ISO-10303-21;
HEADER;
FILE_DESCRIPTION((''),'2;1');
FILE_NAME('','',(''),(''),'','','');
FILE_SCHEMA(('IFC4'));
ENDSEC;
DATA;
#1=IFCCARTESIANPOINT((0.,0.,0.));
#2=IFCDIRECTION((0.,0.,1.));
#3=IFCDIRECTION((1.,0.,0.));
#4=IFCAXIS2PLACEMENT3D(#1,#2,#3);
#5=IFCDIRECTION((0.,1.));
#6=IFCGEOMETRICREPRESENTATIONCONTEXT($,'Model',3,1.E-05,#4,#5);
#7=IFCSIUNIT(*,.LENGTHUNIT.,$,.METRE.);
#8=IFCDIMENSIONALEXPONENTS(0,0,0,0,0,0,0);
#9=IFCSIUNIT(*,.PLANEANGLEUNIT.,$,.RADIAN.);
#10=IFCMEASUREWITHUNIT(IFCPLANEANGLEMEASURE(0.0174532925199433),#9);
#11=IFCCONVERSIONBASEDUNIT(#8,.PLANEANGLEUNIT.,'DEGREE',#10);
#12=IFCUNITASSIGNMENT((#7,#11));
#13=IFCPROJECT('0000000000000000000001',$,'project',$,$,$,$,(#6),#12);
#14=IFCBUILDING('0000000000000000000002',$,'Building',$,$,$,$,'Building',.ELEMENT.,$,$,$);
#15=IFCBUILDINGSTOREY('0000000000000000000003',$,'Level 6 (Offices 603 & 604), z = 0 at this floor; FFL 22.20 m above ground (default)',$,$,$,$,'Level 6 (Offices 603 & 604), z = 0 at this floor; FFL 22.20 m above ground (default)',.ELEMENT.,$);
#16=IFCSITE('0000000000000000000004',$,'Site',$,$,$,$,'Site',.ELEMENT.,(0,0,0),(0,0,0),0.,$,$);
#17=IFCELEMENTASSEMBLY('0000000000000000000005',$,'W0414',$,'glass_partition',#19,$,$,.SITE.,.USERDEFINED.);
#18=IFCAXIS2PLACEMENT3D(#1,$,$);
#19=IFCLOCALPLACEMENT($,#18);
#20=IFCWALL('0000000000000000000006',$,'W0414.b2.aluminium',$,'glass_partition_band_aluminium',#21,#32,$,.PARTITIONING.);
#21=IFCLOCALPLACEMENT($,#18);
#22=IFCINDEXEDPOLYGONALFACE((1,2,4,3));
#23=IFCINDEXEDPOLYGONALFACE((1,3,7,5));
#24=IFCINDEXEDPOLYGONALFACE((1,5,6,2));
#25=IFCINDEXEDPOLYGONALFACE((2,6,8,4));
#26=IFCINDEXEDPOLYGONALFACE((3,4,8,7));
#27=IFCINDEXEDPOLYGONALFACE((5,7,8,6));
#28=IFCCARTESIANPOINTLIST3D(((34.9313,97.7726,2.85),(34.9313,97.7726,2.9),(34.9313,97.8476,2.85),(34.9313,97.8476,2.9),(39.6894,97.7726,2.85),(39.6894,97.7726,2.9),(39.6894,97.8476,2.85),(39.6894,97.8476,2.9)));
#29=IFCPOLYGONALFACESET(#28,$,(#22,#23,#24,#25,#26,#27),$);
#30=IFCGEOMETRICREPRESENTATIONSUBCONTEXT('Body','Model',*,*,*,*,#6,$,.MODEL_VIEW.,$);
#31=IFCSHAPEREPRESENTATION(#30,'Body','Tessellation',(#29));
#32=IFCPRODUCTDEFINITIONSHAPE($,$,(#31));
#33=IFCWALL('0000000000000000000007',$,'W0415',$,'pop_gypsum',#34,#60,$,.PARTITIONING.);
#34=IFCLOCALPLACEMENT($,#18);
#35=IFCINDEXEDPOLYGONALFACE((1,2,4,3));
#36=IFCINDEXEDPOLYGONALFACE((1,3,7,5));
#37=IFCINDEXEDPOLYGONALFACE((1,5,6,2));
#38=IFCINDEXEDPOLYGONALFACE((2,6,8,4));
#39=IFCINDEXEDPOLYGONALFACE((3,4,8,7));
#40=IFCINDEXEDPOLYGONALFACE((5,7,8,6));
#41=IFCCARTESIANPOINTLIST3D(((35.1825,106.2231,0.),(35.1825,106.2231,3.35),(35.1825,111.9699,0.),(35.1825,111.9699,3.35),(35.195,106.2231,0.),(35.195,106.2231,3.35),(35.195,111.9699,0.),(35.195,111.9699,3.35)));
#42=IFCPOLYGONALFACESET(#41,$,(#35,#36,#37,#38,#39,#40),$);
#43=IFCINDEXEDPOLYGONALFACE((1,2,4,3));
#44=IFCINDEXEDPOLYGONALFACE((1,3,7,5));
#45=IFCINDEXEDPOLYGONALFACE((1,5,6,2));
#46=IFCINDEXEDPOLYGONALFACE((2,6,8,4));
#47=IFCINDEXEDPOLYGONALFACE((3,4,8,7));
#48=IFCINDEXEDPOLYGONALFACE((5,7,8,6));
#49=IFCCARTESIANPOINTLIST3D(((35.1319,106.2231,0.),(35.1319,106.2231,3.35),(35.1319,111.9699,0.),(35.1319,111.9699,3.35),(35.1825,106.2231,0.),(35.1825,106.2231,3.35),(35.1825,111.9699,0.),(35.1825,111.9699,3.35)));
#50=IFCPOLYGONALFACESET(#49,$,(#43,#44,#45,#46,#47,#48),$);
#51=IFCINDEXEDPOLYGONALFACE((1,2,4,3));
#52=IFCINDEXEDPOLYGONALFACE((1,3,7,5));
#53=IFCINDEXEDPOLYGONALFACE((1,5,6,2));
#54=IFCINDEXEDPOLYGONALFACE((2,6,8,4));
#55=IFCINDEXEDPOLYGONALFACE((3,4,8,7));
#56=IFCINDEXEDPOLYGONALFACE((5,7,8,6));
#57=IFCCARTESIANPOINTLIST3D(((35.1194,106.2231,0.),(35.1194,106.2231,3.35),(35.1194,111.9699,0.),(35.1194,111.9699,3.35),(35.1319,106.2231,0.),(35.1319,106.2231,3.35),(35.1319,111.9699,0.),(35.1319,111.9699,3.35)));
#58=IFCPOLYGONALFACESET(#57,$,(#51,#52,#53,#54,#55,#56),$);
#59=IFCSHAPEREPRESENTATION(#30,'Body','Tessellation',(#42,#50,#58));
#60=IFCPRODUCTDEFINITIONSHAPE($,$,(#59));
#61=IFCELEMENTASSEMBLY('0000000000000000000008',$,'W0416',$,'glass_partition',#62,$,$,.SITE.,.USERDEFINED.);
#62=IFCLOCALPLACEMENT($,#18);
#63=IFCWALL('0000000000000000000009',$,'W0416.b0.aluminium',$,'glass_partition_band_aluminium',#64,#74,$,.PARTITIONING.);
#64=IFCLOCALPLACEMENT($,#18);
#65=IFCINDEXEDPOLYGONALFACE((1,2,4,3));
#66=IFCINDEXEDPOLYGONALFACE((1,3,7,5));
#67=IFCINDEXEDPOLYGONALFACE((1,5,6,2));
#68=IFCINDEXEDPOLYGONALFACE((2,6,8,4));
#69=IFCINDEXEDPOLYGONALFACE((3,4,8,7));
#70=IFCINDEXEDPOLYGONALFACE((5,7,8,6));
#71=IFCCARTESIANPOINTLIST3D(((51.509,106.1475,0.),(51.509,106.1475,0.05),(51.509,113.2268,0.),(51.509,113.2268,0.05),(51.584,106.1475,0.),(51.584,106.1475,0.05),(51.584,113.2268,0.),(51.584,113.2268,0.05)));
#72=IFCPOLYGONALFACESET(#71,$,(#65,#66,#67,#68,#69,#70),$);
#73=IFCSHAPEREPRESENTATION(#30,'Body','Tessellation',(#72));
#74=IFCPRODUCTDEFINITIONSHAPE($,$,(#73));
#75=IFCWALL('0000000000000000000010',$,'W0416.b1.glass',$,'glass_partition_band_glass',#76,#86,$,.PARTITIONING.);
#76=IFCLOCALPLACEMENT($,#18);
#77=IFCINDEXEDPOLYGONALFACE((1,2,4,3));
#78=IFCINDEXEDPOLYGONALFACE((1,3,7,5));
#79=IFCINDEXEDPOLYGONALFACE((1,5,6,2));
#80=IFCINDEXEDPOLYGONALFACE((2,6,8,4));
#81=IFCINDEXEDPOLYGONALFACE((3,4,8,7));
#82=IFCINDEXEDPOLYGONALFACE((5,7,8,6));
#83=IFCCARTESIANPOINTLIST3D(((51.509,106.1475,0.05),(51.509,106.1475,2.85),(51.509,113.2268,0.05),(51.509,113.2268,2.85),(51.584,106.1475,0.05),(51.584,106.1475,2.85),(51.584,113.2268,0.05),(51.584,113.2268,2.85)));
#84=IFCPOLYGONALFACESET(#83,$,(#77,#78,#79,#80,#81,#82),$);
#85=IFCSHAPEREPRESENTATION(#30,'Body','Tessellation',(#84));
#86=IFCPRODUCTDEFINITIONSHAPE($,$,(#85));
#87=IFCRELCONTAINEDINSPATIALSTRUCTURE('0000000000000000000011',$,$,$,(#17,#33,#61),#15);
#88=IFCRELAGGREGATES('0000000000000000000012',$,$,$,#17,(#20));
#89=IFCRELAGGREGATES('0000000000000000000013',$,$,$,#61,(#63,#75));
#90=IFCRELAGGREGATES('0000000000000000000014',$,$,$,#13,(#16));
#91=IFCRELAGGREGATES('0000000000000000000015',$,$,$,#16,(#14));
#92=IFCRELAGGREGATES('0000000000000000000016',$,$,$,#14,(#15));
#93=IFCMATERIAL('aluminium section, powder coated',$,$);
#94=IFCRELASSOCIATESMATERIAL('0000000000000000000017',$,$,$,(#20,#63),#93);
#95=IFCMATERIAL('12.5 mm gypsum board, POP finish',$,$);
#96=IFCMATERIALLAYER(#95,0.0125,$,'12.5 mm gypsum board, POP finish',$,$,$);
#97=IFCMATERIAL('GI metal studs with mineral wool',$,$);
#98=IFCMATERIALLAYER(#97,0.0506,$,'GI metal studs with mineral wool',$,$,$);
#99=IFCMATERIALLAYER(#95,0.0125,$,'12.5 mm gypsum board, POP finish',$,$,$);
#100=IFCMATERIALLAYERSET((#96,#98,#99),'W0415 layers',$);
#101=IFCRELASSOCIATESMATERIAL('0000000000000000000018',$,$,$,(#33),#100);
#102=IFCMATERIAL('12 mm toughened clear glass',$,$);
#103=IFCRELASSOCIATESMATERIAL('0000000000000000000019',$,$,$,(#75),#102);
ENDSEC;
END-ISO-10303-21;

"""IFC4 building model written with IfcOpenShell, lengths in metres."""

from ifc_helpers import new_model, entity, si_unit, converted_unit, direction, frame, frame_2d, origin_with_axes, place, context, subcontext, project, spatial, rectangle, extrude, material, layer, layer_set, layer_usage, element, aggregate, save


model = new_model("IFC4")

# Units and contexts
model_context = context("Model", 3, precision=1e-05, world=origin_with_axes(), true_north=direction((0.0, 1.0)))
body_context = subcontext(model_context, "Body", "Model", "MODEL_VIEW")
ifc_project = project(units=[si_unit("LENGTHUNIT", "METRE"), converted_unit("PLANEANGLEUNIT", "DEGREE", entity("IfcPlaneAngleMeasure", 0.0174532925199433), si_unit("PLANEANGLEUNIT", "RADIAN"), dimensions=[0, 0, 0, 0, 0, 0, 0])], contexts=[model_context])

# Site, building, storey
site = spatial("IfcSite", under=ifc_project, Name="Site", LongName="Site", CompositionType="ELEMENT", RefLatitude=(0, 0, 0), RefLongitude=(0, 0, 0), RefElevation=0.0)
building = spatial("IfcBuilding", under=site, Name="Building", LongName="Building", CompositionType="ELEMENT")
storey = spatial("IfcBuildingStorey", under=building, Name="Level 6 (Offices 603 & 604), z = 0 at this floor; FFL 22.20 m above ground (default)", LongName="Level 6 (Offices 603 & 604), z = 0 at this floor; FFL 22.20 m above ground (default)", CompositionType="ELEMENT")

# Shared definitions
ifc_material_1 = material(Name="aluminium section, powder coated")
placement = place(None, origin_with_axes())

# Shared definitions
ifc_material_2 = material(Name="12.5 mm gypsum board, POP finish")
ifc_material_3 = material(Name="GI metal studs with mineral wool")

# Shared definitions
ifc_material_4 = material(Name="12 mm toughened clear glass")

# Element assembly, wall
assembly_1 = element("IfcElementAssembly", 1, inside=storey, Name="W0414", ObjectType="glass_partition", AssemblyPlace="SITE", PredefinedType="USERDEFINED")
wall_1 = element("IfcWall", 2, at=placement, material=ifc_material_1, Name="W0414.b2.aluminium", ObjectType="glass_partition_band_aluminium", PredefinedType="PARTITIONING", context=body_context, shape_type="SweptSolid", body=[
    extrude(rectangle(XDim=4.7581, YDim=0.075, at=frame_2d((0.0, 0.0), x_axis=(1.0, 0.0))), frame((37.3103, 97.8101, 2.85), z_axis=(0.0, 0.0, 1.0), x_axis=(1.0, 0.0, 0.0)), (0.0, 0.0, 1.0), 0.05),
])
aggregate(assembly_1, [wall_1])

# Wall
ifc_layer_1 = layer(ifc_material_2, 0.0125, Name="12.5 mm gypsum board, POP finish")
ifc_layer_2 = layer(ifc_material_3, 0.0506, Name="GI metal studs with mineral wool")
ifc_layer_3 = layer(ifc_material_2, 0.0125, Name="12.5 mm gypsum board, POP finish")
ifc_layer_set_1 = layer_set([ifc_layer_1, ifc_layer_2, ifc_layer_3], Name="W0415 layers")
ifc_layer_usage_1 = layer_usage(ifc_layer_set_1, "AXIS2", "POSITIVE", -0.0378)
element("IfcWall", 3, at=placement, inside=storey, material=ifc_layer_usage_1, Name="W0415", ObjectType="pop_gypsum", PredefinedType="PARTITIONING", context=body_context, shape_type="SweptSolid", body=[
    extrude(rectangle(XDim=5.7468, YDim=0.0125, at=frame_2d((0.0, 0.0), x_axis=(0.0, 1.0))), frame((35.1887, 109.0965, 0.0), z_axis=(0.0, 0.0, 1.0), x_axis=(1.0, 0.0, 0.0)), (0.0, 0.0, 1.0), 3.35),
    extrude(rectangle(XDim=5.7468, YDim=0.0506, at=frame_2d((-0.0315, 0.0), x_axis=(0.0, 1.0))), frame((35.1887, 109.0965, 0.0), z_axis=(0.0, 0.0, 1.0), x_axis=(1.0, 0.0, 0.0)), (0.0, 0.0, 1.0), 3.35),
    extrude(rectangle(XDim=5.7468, YDim=0.0125, at=frame_2d((-0.0631, 0.0), x_axis=(0.0, 1.0))), frame((35.1887, 109.0965, 0.0), z_axis=(0.0, 0.0, 1.0), x_axis=(1.0, 0.0, 0.0)), (0.0, 0.0, 1.0), 3.35),
])

# Element assembly, walls
assembly_2 = element("IfcElementAssembly", 4, inside=storey, Name="W0416", ObjectType="glass_partition", AssemblyPlace="SITE", PredefinedType="USERDEFINED")
wall_2 = element("IfcWall", 5, at=placement, material=ifc_material_1, Name="W0416.b0.aluminium", ObjectType="glass_partition_band_aluminium", PredefinedType="PARTITIONING", context=body_context, shape_type="SweptSolid", body=[
    extrude(rectangle(XDim=7.0793, YDim=0.075, at=frame_2d((0.0, 0.0), x_axis=(0.0, 1.0))), frame((51.5465, 109.6872, 0.0), z_axis=(0.0, 0.0, 1.0), x_axis=(1.0, 0.0, 0.0)), (0.0, 0.0, 1.0), 0.05),
])
wall_3 = element("IfcWall", 6, at=placement, material=ifc_material_4, Name="W0416.b1.glass", ObjectType="glass_partition_band_glass", PredefinedType="PARTITIONING", context=body_context, shape_type="SweptSolid", body=[
    extrude(rectangle(XDim=7.0793, YDim=0.075, at=frame_2d((0.0, 0.0), x_axis=(0.0, 1.0))), frame((51.5465, 109.6872, 0.05), z_axis=(0.0, 0.0, 1.0), x_axis=(1.0, 0.0, 0.0)), (0.0, 0.0, 1.0), 2.8),
])
aggregate(assembly_2, [wall_2, wall_3])

save(model, "model.ifc")
